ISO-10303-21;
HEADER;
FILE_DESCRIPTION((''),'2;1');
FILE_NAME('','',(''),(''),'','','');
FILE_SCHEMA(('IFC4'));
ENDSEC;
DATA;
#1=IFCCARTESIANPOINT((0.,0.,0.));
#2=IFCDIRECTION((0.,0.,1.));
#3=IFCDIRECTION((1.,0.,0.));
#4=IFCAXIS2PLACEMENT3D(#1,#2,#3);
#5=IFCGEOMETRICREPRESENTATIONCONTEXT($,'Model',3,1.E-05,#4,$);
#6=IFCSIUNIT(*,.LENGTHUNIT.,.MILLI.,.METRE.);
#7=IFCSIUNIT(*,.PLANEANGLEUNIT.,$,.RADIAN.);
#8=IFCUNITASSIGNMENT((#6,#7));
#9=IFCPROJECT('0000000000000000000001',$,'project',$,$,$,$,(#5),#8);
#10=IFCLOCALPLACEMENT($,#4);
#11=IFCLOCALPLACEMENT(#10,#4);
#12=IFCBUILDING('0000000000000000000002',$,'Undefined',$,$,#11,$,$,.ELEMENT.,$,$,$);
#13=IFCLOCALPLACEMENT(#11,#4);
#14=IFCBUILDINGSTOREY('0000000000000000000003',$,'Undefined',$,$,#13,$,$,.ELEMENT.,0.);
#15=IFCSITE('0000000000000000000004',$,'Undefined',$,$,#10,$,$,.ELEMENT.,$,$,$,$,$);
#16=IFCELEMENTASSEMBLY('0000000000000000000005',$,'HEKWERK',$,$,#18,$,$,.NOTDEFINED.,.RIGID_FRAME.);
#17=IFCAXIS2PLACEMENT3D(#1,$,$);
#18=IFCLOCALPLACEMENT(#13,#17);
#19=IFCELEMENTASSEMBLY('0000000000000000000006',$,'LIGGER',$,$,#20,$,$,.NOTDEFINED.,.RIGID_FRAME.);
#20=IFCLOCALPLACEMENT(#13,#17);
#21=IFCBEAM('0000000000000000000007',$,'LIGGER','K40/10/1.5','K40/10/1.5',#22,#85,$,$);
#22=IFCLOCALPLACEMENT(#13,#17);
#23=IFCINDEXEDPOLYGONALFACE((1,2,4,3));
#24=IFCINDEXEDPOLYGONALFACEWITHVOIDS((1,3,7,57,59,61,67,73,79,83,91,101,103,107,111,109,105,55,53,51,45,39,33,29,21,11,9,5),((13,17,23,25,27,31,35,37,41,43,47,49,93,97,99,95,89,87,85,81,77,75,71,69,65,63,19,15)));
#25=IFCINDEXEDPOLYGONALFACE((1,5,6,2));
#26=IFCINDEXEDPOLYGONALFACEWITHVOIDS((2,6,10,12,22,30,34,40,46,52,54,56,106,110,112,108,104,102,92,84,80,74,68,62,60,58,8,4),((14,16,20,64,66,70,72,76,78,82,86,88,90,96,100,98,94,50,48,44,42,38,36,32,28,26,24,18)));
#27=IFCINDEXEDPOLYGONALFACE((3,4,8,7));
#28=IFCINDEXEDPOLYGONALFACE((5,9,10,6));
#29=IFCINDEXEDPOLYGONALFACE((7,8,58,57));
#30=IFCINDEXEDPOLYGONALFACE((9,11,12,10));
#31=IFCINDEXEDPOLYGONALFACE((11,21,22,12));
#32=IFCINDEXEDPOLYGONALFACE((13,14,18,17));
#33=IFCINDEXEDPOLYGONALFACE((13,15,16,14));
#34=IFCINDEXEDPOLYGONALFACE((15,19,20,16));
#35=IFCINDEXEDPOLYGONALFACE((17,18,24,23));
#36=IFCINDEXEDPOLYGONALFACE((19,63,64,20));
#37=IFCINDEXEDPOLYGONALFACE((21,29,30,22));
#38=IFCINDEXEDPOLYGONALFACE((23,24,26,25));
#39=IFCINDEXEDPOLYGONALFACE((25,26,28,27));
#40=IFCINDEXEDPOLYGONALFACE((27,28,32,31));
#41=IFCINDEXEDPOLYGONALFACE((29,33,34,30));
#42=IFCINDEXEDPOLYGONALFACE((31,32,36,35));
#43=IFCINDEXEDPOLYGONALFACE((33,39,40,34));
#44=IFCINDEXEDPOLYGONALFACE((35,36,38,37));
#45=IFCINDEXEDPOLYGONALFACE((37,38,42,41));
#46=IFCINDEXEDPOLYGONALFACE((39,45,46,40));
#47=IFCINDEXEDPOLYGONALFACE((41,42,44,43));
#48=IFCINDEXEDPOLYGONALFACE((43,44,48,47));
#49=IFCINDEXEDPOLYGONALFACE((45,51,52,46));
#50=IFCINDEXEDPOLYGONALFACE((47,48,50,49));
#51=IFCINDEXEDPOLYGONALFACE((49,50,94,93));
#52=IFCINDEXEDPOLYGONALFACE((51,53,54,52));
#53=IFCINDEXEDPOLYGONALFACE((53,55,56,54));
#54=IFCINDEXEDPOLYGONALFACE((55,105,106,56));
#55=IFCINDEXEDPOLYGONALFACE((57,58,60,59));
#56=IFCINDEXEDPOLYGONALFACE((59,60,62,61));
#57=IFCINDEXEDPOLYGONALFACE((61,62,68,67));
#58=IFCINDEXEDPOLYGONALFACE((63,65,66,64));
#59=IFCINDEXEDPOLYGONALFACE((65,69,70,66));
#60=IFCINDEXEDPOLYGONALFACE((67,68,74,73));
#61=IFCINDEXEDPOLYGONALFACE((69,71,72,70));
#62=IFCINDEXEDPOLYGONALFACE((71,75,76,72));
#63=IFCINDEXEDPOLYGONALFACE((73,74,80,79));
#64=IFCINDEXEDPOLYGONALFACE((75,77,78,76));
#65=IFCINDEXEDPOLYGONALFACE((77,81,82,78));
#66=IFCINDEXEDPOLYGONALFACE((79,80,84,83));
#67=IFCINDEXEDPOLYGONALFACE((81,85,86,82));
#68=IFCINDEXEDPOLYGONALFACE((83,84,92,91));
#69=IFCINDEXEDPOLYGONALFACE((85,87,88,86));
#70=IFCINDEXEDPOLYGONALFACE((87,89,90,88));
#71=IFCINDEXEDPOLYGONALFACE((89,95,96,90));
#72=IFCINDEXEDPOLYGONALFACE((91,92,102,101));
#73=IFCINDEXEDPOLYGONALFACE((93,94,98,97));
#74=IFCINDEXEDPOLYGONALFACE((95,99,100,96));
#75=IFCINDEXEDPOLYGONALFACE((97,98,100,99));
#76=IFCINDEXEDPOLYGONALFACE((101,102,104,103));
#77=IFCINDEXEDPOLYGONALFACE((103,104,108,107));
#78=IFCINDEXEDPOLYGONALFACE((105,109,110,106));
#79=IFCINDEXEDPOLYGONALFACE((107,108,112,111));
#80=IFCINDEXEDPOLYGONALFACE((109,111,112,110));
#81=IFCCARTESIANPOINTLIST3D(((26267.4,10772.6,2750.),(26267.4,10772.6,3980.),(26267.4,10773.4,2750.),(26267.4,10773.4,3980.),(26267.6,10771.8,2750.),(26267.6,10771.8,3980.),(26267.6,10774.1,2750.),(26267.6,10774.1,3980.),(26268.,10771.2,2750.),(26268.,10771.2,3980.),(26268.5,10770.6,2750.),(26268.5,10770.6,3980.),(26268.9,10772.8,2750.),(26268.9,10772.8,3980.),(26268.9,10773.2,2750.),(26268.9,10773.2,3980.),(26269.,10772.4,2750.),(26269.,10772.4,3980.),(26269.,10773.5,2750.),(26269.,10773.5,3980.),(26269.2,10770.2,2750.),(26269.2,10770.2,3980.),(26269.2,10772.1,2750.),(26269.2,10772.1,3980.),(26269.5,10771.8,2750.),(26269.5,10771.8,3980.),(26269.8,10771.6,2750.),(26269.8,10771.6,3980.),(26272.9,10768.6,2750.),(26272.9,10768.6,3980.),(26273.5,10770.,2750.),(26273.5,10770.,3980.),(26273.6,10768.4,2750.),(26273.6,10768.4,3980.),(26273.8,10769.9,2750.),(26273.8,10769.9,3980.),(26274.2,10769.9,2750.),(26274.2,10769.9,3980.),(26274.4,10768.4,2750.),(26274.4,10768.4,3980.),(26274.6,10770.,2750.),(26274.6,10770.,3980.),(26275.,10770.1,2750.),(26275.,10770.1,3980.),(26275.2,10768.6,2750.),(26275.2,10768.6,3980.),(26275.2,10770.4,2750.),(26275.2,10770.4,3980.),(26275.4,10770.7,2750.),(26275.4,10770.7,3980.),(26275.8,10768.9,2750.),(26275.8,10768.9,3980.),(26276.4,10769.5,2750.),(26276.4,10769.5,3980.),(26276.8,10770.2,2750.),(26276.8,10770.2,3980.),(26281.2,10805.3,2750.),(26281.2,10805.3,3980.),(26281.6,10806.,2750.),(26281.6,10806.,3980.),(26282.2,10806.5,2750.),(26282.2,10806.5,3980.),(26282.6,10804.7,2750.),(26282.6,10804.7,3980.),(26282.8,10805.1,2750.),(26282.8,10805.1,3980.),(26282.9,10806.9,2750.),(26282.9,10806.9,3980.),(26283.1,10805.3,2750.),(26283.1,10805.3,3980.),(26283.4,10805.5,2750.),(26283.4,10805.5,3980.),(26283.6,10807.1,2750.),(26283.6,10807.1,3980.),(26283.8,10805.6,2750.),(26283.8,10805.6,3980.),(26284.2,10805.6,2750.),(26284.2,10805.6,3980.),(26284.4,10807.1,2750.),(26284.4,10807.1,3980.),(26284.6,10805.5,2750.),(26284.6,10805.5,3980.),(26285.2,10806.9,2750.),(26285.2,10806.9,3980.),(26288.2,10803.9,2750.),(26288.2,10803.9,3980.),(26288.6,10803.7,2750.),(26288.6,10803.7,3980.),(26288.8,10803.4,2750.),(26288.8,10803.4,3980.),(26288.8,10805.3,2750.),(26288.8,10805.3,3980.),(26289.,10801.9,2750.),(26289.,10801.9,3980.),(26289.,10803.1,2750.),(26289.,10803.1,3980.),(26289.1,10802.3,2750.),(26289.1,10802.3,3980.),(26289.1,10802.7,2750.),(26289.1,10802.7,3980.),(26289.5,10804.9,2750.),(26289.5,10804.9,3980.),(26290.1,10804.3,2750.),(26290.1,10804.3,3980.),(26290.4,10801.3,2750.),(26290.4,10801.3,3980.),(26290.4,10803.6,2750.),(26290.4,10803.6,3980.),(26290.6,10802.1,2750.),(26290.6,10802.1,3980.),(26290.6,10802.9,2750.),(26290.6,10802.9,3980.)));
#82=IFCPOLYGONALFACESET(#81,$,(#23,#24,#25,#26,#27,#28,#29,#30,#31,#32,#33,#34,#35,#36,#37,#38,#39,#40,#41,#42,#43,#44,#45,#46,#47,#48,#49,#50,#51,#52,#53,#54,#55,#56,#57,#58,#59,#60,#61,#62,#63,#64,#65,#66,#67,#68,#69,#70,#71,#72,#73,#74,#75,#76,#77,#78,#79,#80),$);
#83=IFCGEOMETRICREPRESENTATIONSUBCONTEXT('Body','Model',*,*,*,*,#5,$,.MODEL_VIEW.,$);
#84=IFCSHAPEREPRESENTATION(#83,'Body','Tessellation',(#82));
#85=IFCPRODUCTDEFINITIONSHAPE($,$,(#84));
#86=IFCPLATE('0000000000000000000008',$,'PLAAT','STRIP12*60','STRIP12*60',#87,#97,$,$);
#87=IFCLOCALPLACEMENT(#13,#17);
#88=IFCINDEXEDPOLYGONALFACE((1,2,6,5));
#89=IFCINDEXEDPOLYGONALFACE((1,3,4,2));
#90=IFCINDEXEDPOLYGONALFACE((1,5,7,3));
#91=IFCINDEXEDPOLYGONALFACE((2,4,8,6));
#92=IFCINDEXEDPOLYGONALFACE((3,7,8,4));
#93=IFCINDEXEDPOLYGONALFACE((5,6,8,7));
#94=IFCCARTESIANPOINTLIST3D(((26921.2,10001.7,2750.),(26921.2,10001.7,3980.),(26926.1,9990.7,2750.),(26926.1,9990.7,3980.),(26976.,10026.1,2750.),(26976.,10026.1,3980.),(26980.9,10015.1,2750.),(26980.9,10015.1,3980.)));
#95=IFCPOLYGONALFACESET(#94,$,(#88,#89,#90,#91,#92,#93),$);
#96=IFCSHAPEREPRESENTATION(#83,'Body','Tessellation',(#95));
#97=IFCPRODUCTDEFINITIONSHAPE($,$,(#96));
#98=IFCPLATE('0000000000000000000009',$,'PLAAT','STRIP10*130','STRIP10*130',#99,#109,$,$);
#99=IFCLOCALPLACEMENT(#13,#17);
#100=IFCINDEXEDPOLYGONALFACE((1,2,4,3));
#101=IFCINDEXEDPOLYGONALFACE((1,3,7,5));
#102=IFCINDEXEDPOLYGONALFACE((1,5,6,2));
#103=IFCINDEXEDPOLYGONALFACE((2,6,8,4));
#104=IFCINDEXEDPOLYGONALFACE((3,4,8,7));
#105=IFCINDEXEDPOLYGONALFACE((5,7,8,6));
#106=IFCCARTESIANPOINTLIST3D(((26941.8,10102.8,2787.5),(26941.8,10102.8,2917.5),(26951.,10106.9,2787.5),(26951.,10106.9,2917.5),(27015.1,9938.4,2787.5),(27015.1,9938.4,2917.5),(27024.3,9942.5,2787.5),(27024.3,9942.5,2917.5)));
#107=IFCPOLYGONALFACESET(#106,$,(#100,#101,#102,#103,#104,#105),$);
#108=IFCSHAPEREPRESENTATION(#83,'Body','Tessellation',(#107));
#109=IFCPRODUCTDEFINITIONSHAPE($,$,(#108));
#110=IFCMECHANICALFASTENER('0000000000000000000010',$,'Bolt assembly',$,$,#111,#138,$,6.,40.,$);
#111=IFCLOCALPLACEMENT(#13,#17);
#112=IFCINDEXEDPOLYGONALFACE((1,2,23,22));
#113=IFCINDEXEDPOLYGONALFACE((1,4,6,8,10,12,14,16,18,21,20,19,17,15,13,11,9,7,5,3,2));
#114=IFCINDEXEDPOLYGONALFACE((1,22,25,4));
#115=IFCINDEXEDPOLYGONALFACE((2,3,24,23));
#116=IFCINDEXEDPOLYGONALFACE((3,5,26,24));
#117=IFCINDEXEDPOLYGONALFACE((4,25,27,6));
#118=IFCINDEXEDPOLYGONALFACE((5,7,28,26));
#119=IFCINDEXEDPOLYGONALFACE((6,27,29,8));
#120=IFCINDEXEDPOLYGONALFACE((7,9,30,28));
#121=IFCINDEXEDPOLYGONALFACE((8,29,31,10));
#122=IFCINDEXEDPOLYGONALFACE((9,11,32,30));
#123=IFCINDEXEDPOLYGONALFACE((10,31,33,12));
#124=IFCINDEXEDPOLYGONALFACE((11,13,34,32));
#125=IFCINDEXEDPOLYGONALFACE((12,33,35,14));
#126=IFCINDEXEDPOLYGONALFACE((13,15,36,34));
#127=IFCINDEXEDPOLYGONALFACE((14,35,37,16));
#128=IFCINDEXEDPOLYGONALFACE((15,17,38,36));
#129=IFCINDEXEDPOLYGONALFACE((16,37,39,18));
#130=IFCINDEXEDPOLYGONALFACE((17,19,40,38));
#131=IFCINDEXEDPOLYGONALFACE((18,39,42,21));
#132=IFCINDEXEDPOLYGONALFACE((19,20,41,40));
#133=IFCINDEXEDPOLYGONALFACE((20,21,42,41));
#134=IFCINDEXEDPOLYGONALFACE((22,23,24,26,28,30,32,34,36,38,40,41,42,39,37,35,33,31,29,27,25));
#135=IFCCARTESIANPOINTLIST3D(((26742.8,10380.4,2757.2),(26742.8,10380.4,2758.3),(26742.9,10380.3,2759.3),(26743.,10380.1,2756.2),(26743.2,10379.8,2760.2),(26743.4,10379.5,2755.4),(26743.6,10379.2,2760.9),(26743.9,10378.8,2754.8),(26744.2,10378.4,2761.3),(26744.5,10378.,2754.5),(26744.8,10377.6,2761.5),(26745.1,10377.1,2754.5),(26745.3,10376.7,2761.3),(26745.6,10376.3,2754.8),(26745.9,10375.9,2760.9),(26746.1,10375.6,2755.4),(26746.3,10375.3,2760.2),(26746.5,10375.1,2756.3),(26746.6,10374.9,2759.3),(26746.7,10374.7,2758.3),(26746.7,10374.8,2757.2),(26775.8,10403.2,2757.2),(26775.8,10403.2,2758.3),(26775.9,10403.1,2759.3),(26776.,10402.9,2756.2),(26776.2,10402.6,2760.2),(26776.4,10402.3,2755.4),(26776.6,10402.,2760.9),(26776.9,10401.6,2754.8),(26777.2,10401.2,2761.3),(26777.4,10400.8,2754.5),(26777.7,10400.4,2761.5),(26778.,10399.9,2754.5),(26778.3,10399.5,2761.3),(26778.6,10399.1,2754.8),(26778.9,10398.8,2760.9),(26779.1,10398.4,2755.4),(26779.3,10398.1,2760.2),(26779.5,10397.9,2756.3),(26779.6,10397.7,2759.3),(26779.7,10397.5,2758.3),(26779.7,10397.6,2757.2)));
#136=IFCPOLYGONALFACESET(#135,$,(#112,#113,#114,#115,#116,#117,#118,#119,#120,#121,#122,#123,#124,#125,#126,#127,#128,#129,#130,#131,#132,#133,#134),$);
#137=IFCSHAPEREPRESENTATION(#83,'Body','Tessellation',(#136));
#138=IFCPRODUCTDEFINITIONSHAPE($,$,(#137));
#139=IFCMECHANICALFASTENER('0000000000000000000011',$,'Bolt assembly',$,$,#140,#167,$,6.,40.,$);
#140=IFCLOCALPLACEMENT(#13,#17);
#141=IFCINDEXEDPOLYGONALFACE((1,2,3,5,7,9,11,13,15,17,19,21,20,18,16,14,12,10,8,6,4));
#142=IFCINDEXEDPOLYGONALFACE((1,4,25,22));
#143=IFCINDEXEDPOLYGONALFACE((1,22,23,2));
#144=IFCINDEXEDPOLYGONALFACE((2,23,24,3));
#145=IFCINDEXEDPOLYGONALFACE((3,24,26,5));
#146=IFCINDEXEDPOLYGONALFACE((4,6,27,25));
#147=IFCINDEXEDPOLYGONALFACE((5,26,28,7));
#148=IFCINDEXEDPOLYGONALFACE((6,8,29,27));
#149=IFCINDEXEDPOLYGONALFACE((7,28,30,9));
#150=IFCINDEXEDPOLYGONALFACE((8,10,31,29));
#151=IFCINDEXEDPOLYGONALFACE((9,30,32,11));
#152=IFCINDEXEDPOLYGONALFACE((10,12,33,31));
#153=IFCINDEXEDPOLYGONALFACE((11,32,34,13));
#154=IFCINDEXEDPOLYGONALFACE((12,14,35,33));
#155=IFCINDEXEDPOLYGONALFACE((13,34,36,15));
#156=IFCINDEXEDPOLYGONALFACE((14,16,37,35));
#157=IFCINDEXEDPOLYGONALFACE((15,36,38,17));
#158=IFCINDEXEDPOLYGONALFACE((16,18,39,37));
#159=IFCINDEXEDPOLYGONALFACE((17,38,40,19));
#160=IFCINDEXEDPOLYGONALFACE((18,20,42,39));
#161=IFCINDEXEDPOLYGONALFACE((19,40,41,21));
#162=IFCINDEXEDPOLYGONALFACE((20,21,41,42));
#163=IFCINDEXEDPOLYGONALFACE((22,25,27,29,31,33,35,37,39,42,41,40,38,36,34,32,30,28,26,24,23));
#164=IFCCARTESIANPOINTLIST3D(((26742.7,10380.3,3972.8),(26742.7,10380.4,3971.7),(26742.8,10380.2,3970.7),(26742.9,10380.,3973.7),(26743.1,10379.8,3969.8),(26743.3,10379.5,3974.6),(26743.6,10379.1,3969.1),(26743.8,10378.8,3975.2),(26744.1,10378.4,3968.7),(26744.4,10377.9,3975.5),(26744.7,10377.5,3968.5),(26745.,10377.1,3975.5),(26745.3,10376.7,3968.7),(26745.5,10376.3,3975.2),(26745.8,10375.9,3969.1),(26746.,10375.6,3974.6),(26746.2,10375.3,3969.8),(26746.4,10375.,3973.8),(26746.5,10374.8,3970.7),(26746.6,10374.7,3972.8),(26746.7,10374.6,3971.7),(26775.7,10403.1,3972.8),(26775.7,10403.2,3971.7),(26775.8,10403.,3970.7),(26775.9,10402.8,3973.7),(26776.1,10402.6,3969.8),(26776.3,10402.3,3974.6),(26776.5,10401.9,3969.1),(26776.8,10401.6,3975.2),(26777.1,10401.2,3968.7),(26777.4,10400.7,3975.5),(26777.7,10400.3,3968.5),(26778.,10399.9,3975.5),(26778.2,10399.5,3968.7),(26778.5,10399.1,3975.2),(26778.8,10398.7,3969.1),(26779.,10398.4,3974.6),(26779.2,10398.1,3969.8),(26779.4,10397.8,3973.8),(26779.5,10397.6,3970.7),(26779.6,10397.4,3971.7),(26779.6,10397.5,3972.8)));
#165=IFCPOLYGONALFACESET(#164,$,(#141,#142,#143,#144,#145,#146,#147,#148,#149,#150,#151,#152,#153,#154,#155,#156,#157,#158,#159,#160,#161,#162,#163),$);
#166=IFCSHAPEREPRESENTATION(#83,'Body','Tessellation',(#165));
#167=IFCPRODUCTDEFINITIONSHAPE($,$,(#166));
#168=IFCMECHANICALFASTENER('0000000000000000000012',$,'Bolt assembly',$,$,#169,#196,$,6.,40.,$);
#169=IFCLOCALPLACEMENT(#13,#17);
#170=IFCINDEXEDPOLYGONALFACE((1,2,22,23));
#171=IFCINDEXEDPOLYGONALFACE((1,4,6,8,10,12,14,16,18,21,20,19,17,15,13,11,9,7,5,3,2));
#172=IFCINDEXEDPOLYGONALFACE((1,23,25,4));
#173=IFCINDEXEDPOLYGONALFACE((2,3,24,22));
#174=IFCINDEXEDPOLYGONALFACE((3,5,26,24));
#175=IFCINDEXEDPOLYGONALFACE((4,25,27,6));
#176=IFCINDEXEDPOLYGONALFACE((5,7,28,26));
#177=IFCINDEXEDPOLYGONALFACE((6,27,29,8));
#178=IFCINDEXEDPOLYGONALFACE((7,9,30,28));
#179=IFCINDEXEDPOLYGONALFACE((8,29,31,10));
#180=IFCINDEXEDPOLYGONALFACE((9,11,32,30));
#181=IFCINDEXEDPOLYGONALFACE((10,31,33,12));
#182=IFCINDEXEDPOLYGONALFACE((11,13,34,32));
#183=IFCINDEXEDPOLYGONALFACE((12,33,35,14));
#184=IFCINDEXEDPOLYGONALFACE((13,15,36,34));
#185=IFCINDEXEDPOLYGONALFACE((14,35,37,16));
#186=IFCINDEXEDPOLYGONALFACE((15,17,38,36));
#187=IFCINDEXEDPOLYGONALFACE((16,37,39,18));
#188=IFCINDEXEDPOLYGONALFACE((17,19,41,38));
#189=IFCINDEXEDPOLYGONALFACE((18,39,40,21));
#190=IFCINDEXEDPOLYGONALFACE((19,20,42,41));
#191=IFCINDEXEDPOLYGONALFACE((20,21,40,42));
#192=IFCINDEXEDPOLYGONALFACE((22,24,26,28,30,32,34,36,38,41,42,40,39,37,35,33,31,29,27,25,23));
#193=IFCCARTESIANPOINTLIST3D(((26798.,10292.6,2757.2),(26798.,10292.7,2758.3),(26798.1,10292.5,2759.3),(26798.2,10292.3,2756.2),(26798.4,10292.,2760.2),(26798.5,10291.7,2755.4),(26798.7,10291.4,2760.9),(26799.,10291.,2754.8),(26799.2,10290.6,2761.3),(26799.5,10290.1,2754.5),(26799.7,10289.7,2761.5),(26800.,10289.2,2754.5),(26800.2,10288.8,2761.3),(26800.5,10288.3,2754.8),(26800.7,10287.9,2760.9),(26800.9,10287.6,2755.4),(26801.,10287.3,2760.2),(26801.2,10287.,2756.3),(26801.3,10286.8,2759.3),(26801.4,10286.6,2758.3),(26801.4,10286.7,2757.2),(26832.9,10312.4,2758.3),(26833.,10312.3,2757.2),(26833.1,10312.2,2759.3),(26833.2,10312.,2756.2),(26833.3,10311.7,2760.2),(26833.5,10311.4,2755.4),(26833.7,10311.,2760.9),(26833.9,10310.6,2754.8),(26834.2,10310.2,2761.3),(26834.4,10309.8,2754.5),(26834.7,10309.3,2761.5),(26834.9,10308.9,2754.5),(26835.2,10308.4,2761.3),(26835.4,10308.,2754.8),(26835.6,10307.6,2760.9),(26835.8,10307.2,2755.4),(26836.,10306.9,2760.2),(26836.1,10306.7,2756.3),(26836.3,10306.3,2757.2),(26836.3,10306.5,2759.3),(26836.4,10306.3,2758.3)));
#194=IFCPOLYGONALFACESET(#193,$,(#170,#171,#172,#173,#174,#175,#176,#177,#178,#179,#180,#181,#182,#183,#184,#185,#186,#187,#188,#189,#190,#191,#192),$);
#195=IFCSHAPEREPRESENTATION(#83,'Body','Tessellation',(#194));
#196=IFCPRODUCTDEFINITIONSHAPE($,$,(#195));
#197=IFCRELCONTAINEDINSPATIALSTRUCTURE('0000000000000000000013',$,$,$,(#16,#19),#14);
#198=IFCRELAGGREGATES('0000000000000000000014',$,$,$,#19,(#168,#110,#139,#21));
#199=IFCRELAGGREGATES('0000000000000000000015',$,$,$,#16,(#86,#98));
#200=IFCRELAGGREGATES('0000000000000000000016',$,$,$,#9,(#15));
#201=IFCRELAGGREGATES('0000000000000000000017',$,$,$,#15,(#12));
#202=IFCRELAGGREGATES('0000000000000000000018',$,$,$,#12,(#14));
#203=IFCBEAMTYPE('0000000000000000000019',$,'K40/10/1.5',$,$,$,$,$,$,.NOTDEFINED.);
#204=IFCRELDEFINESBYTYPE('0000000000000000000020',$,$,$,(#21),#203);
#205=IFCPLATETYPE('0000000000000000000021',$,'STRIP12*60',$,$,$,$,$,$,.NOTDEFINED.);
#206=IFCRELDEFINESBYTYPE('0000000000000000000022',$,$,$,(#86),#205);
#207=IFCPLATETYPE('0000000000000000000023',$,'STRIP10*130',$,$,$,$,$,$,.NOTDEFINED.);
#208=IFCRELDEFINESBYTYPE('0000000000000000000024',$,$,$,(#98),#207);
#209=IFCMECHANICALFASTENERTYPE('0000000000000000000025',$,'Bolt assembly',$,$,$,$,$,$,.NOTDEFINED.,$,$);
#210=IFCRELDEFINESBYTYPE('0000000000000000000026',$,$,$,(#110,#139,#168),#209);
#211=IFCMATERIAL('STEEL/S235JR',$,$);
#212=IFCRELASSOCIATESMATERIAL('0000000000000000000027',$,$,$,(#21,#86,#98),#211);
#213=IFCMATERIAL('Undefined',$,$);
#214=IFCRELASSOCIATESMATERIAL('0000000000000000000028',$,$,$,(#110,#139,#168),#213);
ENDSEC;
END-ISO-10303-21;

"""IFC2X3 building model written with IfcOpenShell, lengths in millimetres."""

from ifc_helpers import new_model, si_unit, frame, origin_with_axes, origin_2d_with_axis, place, context, subcontext, project, spatial, rectangle, hollow_rectangle, circle, extrude, source, transform, mapped, material, type_object, element, aggregate, save


model = new_model("IFC2X3")

# Units and contexts
model_context = context("Model", 3, precision=1e-05, world=origin_with_axes())
body_context = subcontext(model_context, "Body", "Model", "MODEL_VIEW")
ifc_project = project(units=[si_unit("LENGTHUNIT", "METRE", prefix="MILLI"), si_unit("PLANEANGLEUNIT", "RADIAN")], contexts=[model_context])

# Site, building, storey
site_placement = place(None, origin_with_axes())
site = spatial("IfcSite", under=ifc_project, at=site_placement, Name="Undefined", CompositionType="ELEMENT")
building_placement = place(site_placement, origin_with_axes())
building = spatial("IfcBuilding", under=site, at=building_placement, Name="Undefined", CompositionType="ELEMENT")
storey_placement = place(building_placement, origin_with_axes())
storey = spatial("IfcBuildingStorey", under=building, at=storey_placement, Name="Undefined", CompositionType="ELEMENT", Elevation=0.0)

# Element assemblies
assembly_1_placement = place(storey_placement, origin_with_axes())
assembly_1 = element("IfcElementAssembly", 1, at=assembly_1_placement, inside=storey, Name="HEKWERK", AssemblyPlace="NOTDEFINED", PredefinedType="RIGID_FRAME")
ifc_material_1 = material(Name="STEEL/S235JR")
assembly_2_placement = place(storey_placement, origin_with_axes())
assembly_2 = element("IfcElementAssembly", 2, at=assembly_2_placement, inside=storey, Name="LIGGER", AssemblyPlace="NOTDEFINED", PredefinedType="RIGID_FRAME")
beam_type_1 = type_object("IfcBeamType", Name="K40/10/1.5", PredefinedType="NOTDEFINED")

# Beam
beam_1_placement = place(assembly_2_placement, frame((26279.0, 10787.7, 3980.0), z_axis=(0.399411, 0.916772, 0.0), x_axis=(0.0, 0.0, -1.0)))
beam_1 = element("IfcBeam", 3, at=beam_1_placement, type_object=beam_type_1, material=ifc_material_1, Name="LIGGER", Description="K40/10/1.5", ObjectType="K40/10/1.5", context=body_context, shape_type="SweptSolid", body=[
    extrude(hollow_rectangle(XDim=10.0, YDim=40.0, WallThickness=1.5, InnerFilletRadius=1.5, OuterFilletRadius=3.0, at=origin_2d_with_axis()), frame((1230.0, 0.0, 0.0), z_axis=(-1.0, 0.0, 0.0), x_axis=(0.0, -1.0, 0.0)), (0.0, 0.0, 1.0), 1230.0),
])

# Plates
plate_type_1 = type_object("IfcPlateType", Name="STRIP12*60", PredefinedType="NOTDEFINED")
plate_1_placement = place(assembly_1_placement, frame((26951.1, 10008.4, 3980.0), z_axis=(0.913309, 0.407268, 0.0), x_axis=(0.0, 0.0, -1.0)))
plate_1 = element("IfcPlate", 4, at=plate_1_placement, type_object=plate_type_1, material=ifc_material_1, Name="PLAAT", Description="STRIP12*60", ObjectType="STRIP12*60", context=body_context, shape_type="SweptSolid", body=[
    extrude(rectangle(XDim=12.0, YDim=60.0, at=origin_2d_with_axis()), frame((1230.0, 0.0, 0.0), z_axis=(-1.0, 0.0, 0.0), x_axis=(0.0, -1.0, 0.0)), (0.0, 0.0, 1.0), 1230.0),
])
plate_type_2 = type_object("IfcPlateType", Name="STRIP10*130", PredefinedType="NOTDEFINED")
plate_2_placement = place(assembly_1_placement, frame((26946.4, 10104.9, 2852.5), z_axis=(0.0, 0.0, 1.0), x_axis=(0.407268, -0.913309, 0.0)))
plate_2 = element("IfcPlate", 5, at=plate_2_placement, type_object=plate_type_2, material=ifc_material_1, Name="PLAAT", Description="STRIP10*130", ObjectType="STRIP10*130", context=body_context, shape_type="SweptSolid", body=[
    extrude(rectangle(XDim=10.0, YDim=130.0, at=origin_2d_with_axis()), frame((180.0, 0.0, 0.0), z_axis=(-1.0, 0.0, 0.0), x_axis=(0.0, -1.0, 0.0)), (0.0, 0.0, 1.0), 180.0),
])

# Mechanical fasteners
ifc_material_2 = material(Name="Undefined")
mechanical_fastener_type = type_object("IfcMechanicalFastenerType", Name="Bolt assembly")
shared_shape_1 = source(origin_with_axes(), body_context, "Body", "SweptSolid", [
    extrude(circle(Radius=3.5, at=origin_2d_with_axis()), frame((0.0, -20.0, 0.0), z_axis=(0.0, 1.0, 0.0), x_axis=(1.0, 0.0, 0.0)), (0.0, 0.0, 1.0), 40.1),
])
mechanical_fastener_1_placement = place(assembly_2_placement, frame((26761.2, 10388.9, 2758.0), z_axis=(-0.568686, 0.822555, 0.0), x_axis=(0.0, 0.0, 1.0)))
mechanical_fastener_1 = element("IfcMechanicalFastener", 6, at=mechanical_fastener_1_placement, type_object=mechanical_fastener_type, material=ifc_material_2, Name="Bolt assembly", NominalDiameter=6.0, NominalLength=40.0, context=body_context, shape_type="MappedRepresentation", body=[
    mapped(shared_shape_1, transform((0.0, 0.0, 0.0))),
])
mechanical_fastener_2_placement = place(assembly_2_placement, frame((26761.2, 10388.9, 3972.0), z_axis=(-0.568686, 0.822555, 0.0), x_axis=(0.0, 0.0, -1.0)))
mechanical_fastener_2 = element("IfcMechanicalFastener", 7, at=mechanical_fastener_2_placement, type_object=mechanical_fastener_type, material=ifc_material_2, Name="Bolt assembly", NominalDiameter=6.0, NominalLength=40.0, context=body_context, shape_type="MappedRepresentation", body=[
    mapped(shared_shape_1, transform((0.0, 0.0, 0.0))),
])
shared_shape_2 = source(origin_with_axes(), body_context, "Body", "SweptSolid", [
    extrude(circle(Radius=3.5, at=origin_2d_with_axis()), frame((0.0, 0.0, 0.0), z_axis=(0.0, 1.0, 0.0), x_axis=(1.0, 0.0, 0.0)), (0.0, 0.0, 1.0), 40.1),
])
mechanical_fastener_3_placement = place(assembly_2_placement, frame((26799.7, 10289.7, 2758.0), z_axis=(-0.490275, 0.871568, 0.0), x_axis=(0.0, 0.0, 1.0)))
mechanical_fastener_3 = element("IfcMechanicalFastener", 8, at=mechanical_fastener_3_placement, type_object=mechanical_fastener_type, material=ifc_material_2, Name="Bolt assembly", NominalDiameter=6.0, NominalLength=40.0, context=body_context, shape_type="MappedRepresentation", body=[
    mapped(shared_shape_2, transform((0.0, 0.0, 0.0))),
])
aggregate(assembly_2, [mechanical_fastener_3, mechanical_fastener_1, mechanical_fastener_2, beam_1])
aggregate(assembly_1, [plate_1, plate_2])

save(model, "model.ifc")
